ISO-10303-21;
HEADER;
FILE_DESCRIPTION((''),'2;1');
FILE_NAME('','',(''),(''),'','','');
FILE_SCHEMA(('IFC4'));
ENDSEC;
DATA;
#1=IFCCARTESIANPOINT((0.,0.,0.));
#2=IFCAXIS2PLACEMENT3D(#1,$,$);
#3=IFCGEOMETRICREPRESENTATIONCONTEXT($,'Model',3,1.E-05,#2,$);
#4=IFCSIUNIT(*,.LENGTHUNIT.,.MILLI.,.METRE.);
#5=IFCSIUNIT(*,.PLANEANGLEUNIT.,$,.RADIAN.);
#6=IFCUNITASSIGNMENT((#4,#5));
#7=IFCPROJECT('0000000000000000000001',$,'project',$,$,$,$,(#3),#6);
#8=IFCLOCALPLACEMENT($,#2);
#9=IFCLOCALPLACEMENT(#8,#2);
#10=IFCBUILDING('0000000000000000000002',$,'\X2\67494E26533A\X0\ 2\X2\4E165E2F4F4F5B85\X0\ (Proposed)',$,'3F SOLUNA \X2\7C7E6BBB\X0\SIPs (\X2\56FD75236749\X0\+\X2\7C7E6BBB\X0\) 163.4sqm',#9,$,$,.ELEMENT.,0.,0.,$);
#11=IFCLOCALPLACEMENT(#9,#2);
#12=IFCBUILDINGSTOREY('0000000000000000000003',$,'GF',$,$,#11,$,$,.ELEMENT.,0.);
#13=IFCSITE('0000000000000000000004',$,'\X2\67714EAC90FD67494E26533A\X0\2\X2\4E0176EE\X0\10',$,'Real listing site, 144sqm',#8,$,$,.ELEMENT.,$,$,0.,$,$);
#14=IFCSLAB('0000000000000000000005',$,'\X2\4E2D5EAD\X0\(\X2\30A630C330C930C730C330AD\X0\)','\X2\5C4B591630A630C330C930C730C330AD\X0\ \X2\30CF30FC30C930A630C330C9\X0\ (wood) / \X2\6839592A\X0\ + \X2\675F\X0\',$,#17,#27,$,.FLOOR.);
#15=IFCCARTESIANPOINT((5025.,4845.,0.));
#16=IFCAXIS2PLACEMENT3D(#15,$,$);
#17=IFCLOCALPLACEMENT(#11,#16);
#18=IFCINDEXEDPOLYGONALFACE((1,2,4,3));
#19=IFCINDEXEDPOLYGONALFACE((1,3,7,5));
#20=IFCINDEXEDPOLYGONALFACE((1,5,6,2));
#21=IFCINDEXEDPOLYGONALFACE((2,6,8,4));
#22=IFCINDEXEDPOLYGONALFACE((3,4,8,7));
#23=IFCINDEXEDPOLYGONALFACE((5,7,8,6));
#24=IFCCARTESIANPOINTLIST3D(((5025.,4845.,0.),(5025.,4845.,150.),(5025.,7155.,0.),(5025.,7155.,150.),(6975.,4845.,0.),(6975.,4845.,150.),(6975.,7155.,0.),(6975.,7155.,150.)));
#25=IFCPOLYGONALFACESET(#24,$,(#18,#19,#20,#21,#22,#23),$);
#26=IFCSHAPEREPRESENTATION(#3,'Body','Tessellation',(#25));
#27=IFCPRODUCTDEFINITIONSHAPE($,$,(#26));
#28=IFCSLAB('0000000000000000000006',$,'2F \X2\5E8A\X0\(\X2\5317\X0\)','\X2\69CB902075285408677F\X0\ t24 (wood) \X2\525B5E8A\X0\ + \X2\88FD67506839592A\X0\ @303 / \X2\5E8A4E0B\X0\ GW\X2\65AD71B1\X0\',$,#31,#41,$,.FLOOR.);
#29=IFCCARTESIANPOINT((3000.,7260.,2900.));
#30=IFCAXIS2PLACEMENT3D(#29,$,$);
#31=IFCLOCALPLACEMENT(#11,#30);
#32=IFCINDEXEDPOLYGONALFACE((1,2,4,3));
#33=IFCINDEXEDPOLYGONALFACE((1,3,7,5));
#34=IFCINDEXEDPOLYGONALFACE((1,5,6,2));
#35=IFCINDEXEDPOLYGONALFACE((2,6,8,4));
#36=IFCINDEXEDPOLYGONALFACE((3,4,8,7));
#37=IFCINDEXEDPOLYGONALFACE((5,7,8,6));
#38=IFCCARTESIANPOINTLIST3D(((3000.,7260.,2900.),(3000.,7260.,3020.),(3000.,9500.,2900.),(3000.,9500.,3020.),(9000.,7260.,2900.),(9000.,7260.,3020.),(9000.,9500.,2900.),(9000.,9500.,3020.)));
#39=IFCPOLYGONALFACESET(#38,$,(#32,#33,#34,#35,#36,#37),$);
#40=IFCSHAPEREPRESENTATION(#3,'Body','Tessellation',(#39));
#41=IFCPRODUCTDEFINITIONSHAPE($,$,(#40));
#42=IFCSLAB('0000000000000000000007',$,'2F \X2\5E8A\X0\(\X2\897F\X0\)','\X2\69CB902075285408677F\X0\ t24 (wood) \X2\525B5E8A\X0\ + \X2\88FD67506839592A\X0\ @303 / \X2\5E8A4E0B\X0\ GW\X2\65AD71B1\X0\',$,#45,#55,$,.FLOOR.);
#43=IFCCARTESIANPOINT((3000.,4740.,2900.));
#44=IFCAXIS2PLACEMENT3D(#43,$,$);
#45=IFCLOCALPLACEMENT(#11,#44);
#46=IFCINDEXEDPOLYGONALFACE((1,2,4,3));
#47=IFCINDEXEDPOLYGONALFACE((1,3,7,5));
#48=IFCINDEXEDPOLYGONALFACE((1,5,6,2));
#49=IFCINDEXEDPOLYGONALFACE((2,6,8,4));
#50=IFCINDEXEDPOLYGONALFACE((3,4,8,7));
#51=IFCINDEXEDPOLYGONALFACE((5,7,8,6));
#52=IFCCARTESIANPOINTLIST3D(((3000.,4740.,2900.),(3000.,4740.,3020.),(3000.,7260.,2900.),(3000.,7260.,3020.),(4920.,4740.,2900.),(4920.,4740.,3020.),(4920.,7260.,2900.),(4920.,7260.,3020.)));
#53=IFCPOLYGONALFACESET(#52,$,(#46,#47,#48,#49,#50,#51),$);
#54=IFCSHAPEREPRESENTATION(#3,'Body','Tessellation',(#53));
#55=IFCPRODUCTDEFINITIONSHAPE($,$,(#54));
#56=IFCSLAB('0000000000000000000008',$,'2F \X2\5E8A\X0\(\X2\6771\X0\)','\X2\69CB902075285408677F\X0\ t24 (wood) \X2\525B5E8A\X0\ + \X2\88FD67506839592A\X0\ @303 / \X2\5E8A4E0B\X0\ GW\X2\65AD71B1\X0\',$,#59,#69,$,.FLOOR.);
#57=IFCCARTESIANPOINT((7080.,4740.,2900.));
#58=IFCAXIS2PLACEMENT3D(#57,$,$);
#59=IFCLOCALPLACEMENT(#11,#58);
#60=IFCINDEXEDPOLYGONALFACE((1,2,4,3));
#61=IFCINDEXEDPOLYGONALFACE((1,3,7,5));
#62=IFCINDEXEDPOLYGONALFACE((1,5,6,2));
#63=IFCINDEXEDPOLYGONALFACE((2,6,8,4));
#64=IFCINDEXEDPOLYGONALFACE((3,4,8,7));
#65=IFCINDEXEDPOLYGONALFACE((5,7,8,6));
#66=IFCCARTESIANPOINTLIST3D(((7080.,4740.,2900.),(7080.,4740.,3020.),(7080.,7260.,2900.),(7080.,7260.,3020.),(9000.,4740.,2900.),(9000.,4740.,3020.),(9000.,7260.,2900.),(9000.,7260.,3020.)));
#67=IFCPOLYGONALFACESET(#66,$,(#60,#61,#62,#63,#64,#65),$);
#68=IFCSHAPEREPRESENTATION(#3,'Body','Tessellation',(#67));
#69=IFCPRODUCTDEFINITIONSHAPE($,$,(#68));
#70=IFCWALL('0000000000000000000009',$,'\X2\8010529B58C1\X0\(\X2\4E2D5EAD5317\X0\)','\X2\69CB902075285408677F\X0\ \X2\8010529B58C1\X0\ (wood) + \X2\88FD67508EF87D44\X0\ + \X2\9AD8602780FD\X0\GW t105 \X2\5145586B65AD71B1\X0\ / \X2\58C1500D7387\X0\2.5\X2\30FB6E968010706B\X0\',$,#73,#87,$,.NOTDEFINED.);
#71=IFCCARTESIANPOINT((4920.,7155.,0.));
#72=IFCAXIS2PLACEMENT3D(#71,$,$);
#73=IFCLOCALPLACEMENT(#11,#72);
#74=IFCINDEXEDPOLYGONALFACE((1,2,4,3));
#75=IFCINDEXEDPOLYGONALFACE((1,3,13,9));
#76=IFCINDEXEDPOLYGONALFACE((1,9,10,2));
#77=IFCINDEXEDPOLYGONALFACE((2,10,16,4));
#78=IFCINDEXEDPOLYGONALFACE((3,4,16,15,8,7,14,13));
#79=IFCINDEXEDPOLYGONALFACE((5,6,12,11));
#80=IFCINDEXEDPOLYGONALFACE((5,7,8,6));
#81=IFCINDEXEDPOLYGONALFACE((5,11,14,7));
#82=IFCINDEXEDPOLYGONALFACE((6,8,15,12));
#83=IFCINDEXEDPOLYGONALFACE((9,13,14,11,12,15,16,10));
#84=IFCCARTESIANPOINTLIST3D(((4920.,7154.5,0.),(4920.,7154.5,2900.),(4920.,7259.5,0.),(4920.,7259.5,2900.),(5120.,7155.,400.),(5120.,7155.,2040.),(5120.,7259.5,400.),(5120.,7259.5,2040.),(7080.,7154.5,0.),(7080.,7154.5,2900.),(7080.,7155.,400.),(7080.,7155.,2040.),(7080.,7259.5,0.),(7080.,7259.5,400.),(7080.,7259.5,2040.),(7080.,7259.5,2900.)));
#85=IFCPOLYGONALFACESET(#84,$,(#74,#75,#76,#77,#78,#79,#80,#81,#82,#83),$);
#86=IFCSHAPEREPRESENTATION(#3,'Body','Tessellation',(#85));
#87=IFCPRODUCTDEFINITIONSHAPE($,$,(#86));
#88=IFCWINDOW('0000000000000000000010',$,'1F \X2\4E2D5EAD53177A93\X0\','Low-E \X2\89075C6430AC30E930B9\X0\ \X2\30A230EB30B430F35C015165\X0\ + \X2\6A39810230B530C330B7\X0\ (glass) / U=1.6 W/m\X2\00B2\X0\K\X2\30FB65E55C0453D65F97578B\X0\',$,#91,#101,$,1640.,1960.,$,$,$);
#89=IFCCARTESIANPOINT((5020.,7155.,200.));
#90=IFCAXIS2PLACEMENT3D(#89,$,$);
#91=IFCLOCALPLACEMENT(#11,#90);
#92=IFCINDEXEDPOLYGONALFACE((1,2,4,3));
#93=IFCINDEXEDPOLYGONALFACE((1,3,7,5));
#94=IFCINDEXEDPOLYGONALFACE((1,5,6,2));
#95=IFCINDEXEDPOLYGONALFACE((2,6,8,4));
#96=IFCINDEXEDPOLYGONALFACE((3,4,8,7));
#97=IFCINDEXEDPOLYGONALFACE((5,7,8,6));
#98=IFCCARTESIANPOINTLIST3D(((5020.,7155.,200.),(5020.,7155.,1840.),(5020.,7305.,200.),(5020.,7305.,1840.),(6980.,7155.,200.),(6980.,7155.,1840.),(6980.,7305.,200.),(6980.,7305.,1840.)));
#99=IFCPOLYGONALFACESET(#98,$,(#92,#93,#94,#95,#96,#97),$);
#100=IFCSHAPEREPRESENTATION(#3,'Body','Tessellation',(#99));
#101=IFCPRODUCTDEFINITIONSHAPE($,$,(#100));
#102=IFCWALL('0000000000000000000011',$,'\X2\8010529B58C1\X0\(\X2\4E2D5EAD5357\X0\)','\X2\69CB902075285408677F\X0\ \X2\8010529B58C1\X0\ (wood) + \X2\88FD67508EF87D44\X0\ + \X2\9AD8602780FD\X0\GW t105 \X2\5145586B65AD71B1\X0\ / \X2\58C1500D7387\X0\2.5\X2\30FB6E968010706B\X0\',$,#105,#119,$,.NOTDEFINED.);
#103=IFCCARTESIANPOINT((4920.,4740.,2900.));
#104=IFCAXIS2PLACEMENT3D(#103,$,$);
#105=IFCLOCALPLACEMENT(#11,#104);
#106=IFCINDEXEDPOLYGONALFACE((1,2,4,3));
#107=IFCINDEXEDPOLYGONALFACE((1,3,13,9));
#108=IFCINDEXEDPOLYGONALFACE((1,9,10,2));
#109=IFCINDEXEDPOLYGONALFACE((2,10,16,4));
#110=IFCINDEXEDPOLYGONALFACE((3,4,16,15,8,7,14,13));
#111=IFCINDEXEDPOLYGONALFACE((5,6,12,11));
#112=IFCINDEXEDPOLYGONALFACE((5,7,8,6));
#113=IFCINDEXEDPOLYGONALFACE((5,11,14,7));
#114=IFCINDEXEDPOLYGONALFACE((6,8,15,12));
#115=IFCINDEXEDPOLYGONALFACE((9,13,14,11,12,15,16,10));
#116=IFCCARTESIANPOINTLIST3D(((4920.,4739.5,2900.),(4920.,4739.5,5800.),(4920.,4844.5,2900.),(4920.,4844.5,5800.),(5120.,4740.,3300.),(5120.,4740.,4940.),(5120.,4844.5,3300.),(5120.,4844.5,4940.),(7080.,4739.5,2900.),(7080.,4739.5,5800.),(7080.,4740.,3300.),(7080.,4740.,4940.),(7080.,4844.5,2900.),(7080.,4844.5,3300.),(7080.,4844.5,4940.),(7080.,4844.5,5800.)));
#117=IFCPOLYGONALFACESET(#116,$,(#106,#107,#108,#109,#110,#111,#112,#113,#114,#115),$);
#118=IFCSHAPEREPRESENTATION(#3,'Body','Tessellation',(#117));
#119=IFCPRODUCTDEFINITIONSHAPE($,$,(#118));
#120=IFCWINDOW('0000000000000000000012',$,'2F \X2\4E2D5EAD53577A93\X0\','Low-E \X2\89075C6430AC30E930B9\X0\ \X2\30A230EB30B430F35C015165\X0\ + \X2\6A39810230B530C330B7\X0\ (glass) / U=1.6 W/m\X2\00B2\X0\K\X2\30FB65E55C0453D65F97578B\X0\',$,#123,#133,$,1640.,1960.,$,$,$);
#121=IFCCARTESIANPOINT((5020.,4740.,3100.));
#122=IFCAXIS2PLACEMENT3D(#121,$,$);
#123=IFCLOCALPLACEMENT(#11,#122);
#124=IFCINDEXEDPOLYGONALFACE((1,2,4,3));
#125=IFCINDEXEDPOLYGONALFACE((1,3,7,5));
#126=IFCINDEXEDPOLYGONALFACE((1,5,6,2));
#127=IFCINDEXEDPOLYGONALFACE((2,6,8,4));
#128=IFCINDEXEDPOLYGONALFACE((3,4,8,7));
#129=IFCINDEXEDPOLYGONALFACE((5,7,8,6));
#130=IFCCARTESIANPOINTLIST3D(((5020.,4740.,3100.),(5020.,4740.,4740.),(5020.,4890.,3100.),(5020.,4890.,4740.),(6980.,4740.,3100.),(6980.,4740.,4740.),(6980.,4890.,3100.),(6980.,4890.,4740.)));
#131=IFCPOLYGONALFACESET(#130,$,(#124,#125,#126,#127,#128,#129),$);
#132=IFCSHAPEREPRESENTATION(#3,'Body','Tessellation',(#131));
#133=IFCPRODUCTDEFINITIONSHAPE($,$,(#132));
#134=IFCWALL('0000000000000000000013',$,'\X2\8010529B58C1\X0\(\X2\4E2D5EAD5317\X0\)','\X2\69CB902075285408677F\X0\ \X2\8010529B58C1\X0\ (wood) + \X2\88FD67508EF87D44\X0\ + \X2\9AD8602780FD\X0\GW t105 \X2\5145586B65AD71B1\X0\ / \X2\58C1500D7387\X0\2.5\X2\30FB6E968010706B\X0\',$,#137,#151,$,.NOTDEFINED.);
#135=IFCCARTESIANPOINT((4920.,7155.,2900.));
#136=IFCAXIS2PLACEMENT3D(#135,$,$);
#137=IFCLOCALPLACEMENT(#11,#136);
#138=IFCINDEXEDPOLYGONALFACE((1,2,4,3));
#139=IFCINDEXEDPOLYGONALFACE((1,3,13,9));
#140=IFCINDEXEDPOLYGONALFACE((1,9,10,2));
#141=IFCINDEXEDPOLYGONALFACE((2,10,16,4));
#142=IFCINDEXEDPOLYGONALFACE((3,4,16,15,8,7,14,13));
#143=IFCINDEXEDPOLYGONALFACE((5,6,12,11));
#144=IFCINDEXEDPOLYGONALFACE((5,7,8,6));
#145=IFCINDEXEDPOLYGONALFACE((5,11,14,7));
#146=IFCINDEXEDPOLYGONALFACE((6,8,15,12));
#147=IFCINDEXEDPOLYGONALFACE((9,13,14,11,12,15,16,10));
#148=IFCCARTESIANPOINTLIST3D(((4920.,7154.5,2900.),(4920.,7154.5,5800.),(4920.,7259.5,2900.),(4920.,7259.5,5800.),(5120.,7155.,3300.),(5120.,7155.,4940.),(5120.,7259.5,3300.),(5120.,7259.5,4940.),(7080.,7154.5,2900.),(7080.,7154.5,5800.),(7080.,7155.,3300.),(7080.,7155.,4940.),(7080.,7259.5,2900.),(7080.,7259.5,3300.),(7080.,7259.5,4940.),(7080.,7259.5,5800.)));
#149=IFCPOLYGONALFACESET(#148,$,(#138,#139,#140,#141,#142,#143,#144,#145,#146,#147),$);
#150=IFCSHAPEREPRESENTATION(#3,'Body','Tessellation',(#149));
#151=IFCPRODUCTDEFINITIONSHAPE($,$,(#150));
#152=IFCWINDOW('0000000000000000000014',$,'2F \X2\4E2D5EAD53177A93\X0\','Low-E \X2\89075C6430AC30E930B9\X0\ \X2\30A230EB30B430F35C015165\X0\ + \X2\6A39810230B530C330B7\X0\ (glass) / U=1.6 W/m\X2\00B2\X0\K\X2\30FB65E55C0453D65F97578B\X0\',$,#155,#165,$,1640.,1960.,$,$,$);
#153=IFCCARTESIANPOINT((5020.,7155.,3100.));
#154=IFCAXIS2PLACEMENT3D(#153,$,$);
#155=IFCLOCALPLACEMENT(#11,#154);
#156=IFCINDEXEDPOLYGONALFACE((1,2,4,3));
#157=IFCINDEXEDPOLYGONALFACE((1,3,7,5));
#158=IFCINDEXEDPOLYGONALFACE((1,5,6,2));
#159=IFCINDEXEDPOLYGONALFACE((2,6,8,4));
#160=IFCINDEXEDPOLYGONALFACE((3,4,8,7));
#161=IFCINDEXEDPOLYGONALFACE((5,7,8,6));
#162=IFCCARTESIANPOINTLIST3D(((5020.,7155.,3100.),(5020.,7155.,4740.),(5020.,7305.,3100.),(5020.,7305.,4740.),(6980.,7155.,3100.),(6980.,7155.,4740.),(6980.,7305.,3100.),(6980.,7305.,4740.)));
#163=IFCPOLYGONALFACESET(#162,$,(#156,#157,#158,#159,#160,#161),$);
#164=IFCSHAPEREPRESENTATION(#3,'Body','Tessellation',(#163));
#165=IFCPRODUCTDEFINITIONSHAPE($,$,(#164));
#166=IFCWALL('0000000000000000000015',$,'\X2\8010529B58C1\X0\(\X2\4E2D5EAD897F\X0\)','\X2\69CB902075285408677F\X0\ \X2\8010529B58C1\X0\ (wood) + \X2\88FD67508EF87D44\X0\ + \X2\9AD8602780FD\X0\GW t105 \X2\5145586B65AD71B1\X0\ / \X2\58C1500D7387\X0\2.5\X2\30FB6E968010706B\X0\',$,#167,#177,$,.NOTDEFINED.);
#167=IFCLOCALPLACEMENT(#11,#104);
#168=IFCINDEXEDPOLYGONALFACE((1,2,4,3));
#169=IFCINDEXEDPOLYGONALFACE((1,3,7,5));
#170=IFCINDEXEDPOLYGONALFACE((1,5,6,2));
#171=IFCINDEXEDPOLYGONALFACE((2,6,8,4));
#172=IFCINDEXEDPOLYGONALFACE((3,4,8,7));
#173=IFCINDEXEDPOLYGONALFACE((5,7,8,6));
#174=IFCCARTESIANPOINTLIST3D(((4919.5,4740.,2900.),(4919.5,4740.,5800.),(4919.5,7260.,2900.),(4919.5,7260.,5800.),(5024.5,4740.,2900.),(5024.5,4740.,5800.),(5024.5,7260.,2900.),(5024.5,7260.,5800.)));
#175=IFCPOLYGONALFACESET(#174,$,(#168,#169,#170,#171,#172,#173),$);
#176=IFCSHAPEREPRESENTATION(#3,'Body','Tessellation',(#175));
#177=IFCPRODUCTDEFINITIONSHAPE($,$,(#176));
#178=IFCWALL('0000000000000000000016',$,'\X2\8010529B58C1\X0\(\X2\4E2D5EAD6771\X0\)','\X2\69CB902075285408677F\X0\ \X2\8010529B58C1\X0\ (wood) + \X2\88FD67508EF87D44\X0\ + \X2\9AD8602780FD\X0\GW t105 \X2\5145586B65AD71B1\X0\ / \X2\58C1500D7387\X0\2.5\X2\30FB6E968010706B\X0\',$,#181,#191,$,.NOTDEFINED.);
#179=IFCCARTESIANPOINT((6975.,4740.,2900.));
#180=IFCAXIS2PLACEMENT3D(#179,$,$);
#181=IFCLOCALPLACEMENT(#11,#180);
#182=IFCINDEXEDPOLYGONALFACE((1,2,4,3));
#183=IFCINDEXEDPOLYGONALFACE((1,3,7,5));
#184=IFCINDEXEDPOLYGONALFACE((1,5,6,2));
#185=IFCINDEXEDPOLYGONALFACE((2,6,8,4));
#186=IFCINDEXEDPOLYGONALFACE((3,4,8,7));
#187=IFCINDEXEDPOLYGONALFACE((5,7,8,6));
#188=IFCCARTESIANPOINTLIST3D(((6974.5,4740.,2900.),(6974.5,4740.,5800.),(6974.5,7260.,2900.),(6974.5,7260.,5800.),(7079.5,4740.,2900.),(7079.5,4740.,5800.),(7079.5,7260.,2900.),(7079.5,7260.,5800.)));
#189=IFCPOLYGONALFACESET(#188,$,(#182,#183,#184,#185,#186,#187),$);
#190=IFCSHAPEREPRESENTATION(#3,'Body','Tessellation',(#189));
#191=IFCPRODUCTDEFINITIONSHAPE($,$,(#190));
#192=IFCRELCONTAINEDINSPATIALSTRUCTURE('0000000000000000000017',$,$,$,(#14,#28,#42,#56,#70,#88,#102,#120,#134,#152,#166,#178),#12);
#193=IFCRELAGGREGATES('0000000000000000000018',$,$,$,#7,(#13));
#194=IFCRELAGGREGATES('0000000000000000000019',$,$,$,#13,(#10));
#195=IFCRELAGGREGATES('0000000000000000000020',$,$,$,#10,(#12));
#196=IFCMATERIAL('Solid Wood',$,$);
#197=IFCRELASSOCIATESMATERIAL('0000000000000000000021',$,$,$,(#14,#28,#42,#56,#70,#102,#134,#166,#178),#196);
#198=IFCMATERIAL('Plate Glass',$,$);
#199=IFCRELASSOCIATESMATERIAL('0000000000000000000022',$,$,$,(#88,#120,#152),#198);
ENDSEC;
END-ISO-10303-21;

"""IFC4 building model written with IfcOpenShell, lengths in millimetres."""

from ifc_helpers import new_model, si_unit, frame, frame_2d, origin, place, context, project, spatial, rectangle, extrude, material, element, fill, save


model = new_model("IFC4")

# Units and contexts
model_context = context("Model", 3, precision=1e-05, world=origin())
ifc_project = project(units=[si_unit("LENGTHUNIT", "METRE", prefix="MILLI"), si_unit("PLANEANGLEUNIT", "RADIAN")], contexts=[model_context])

# Site, building, storey
site_placement = place(None, origin())
site = spatial("IfcSite", under=ifc_project, at=site_placement, Name="東京都杉並区2丁目10", ObjectType="Real listing site, 144sqm", CompositionType="ELEMENT", RefElevation=0.0)
building_placement = place(site_placement, origin())
building = spatial("IfcBuilding", under=site, at=building_placement, Name="杉並区 2世帯住宅 (Proposed)", ObjectType="3F SOLUNA 籾殻SIPs (国産杉+籾殻) 163.4sqm", CompositionType="ELEMENT", ElevationOfRefHeight=0.0, ElevationOfTerrain=0.0)
storey_placement = place(building_placement, origin())
storey = spatial("IfcBuildingStorey", under=building, at=storey_placement, Name="GF", CompositionType="ELEMENT", Elevation=0.0)

# Slabs
ifc_material_1 = material(Name="Solid Wood")
slab_1_placement = place(storey_placement, frame((5025.0, 4845.0, 0.0)))
element("IfcSlab", 1, at=slab_1_placement, inside=storey, material=ifc_material_1, Name="中庭(ウッドデッキ)", Description="屋外ウッドデッキ ハードウッド (wood) / 根太 + 束", PredefinedType="FLOOR", context=model_context, shape_type="SweptSolid", body=[
    extrude(rectangle(XDim=1950.0, YDim=2310.0, at=frame_2d((975.0, 1155.0))), frame((5025.0, 4845.0, 0.0)), (0.0, 0.0, 1.0), 150.0),
])
slab_2_placement = place(storey_placement, frame((3000.0, 7260.0, 2900.0)))
element("IfcSlab", 2, at=slab_2_placement, inside=storey, material=ifc_material_1, Name="2F 床(北)", Description="構造用合板 t24 (wood) 剛床 + 製材根太 @303 / 床下 GW断熱", PredefinedType="FLOOR", context=model_context, shape_type="SweptSolid", body=[
    extrude(rectangle(XDim=6000.0, YDim=2240.0, at=frame_2d((3000.0, 1120.0))), frame((3000.0, 7260.0, 2900.0)), (0.0, 0.0, 1.0), 120.0),
])
slab_3_placement = place(storey_placement, frame((3000.0, 4740.0, 2900.0)))
element("IfcSlab", 3, at=slab_3_placement, inside=storey, material=ifc_material_1, Name="2F 床(西)", Description="構造用合板 t24 (wood) 剛床 + 製材根太 @303 / 床下 GW断熱", PredefinedType="FLOOR", context=model_context, shape_type="SweptSolid", body=[
    extrude(rectangle(XDim=1920.0, YDim=2520.0, at=frame_2d((960.0, 1260.0))), frame((3000.0, 4740.0, 2900.0)), (0.0, 0.0, 1.0), 120.0),
])
slab_4_placement = place(storey_placement, frame((7080.0, 4740.0, 2900.0)))
element("IfcSlab", 4, at=slab_4_placement, inside=storey, material=ifc_material_1, Name="2F 床(東)", Description="構造用合板 t24 (wood) 剛床 + 製材根太 @303 / 床下 GW断熱", PredefinedType="FLOOR", context=model_context, shape_type="SweptSolid", body=[
    extrude(rectangle(XDim=1920.0, YDim=2520.0, at=frame_2d((960.0, 1260.0))), frame((7080.0, 4740.0, 2900.0)), (0.0, 0.0, 1.0), 120.0),
])

# Wall, opening, window
wall_1_placement = place(storey_placement, frame((4920.0, 7155.0, 0.0)))
wall_1 = element("IfcWall", 5, at=wall_1_placement, inside=storey, material=ifc_material_1, Name="耐力壁(中庭北)", Description="構造用合板 耐力壁 (wood) + 製材軸組 + 高性能GW t105 充填断熱 / 壁倍率2.5・準耐火", PredefinedType="NOTDEFINED", context=model_context, shape_type="SweptSolid", body=[
    extrude(rectangle(XDim=2160.0, YDim=105.0, at=frame_2d((1080.0, 52.0))), frame((4920.0, 7155.0, 0.0)), (0.0, 0.0, 1.0), 2900.0),
])
opening_1_placement = place(storey_placement, frame((5020.0, 7155.0, 200.0)))
opening_1 = element("IfcOpeningElement", 6, at=opening_1_placement, cuts=wall_1, PredefinedType="NOTDEFINED", context=model_context, shape_type="SweptSolid", body=[
    extrude(rectangle(XDim=1960.0, YDim=150.0, at=frame_2d((980.0, 75.0))), frame((5020.0, 7155.0, 200.0)), (0.0, 0.0, 1.0), 1640.0),
])
ifc_material_2 = material(Name="Plate Glass")
window_1_placement = place(storey_placement, frame((5020.0, 7155.0, 200.0)))
window_1 = element("IfcWindow", 7, at=window_1_placement, inside=storey, material=ifc_material_2, Name="1F 中庭北窓", Description="Low-E 複層ガラス アルゴン封入 + 樹脂サッシ (glass) / U=1.6 W/m²K・日射取得型", OverallHeight=1640.0, OverallWidth=1960.0, context=model_context, shape_type="SweptSolid", body=[
    extrude(rectangle(XDim=1960.0, YDim=150.0, at=frame_2d((980.0, 75.0))), frame((5020.0, 7155.0, 200.0)), (0.0, 0.0, 1.0), 1640.0),
])
fill(opening_1, window_1)

# Walls, openings, windows
wall_2_placement = place(storey_placement, frame((4920.0, 4740.0, 2900.0)))
wall_2 = element("IfcWall", 8, at=wall_2_placement, inside=storey, material=ifc_material_1, Name="耐力壁(中庭南)", Description="構造用合板 耐力壁 (wood) + 製材軸組 + 高性能GW t105 充填断熱 / 壁倍率2.5・準耐火", PredefinedType="NOTDEFINED", context=model_context, shape_type="SweptSolid", body=[
    extrude(rectangle(XDim=2160.0, YDim=105.0, at=frame_2d((1080.0, 52.0))), frame((4920.0, 4740.0, 2900.0)), (0.0, 0.0, 1.0), 2900.0),
])
opening_2_placement = place(storey_placement, frame((5020.0, 4740.0, 3100.0)))
opening_2 = element("IfcOpeningElement", 9, at=opening_2_placement, cuts=wall_2, PredefinedType="NOTDEFINED", context=model_context, shape_type="SweptSolid", body=[
    extrude(rectangle(XDim=1960.0, YDim=150.0, at=frame_2d((980.0, 75.0))), frame((5020.0, 4740.0, 3100.0)), (0.0, 0.0, 1.0), 1640.0),
])
window_2_placement = place(storey_placement, frame((5020.0, 4740.0, 3100.0)))
window_2 = element("IfcWindow", 10, at=window_2_placement, inside=storey, material=ifc_material_2, Name="2F 中庭南窓", Description="Low-E 複層ガラス アルゴン封入 + 樹脂サッシ (glass) / U=1.6 W/m²K・日射取得型", OverallHeight=1640.0, OverallWidth=1960.0, context=model_context, shape_type="SweptSolid", body=[
    extrude(rectangle(XDim=1960.0, YDim=150.0, at=frame_2d((980.0, 75.0))), frame((5020.0, 4740.0, 3100.0)), (0.0, 0.0, 1.0), 1640.0),
])
fill(opening_2, window_2)
wall_3_placement = place(storey_placement, frame((4920.0, 7155.0, 2900.0)))
wall_3 = element("IfcWall", 11, at=wall_3_placement, inside=storey, material=ifc_material_1, Name="耐力壁(中庭北)", Description="構造用合板 耐力壁 (wood) + 製材軸組 + 高性能GW t105 充填断熱 / 壁倍率2.5・準耐火", PredefinedType="NOTDEFINED", context=model_context, shape_type="SweptSolid", body=[
    extrude(rectangle(XDim=2160.0, YDim=105.0, at=frame_2d((1080.0, 52.0))), frame((4920.0, 7155.0, 2900.0)), (0.0, 0.0, 1.0), 2900.0),
])
opening_3_placement = place(storey_placement, frame((5020.0, 7155.0, 3100.0)))
opening_3 = element("IfcOpeningElement", 12, at=opening_3_placement, cuts=wall_3, PredefinedType="NOTDEFINED", context=model_context, shape_type="SweptSolid", body=[
    extrude(rectangle(XDim=1960.0, YDim=150.0, at=frame_2d((980.0, 75.0))), frame((5020.0, 7155.0, 3100.0)), (0.0, 0.0, 1.0), 1640.0),
])
window_3_placement = place(storey_placement, frame((5020.0, 7155.0, 3100.0)))
window_3 = element("IfcWindow", 13, at=window_3_placement, inside=storey, material=ifc_material_2, Name="2F 中庭北窓", Description="Low-E 複層ガラス アルゴン封入 + 樹脂サッシ (glass) / U=1.6 W/m²K・日射取得型", OverallHeight=1640.0, OverallWidth=1960.0, context=model_context, shape_type="SweptSolid", body=[
    extrude(rectangle(XDim=1960.0, YDim=150.0, at=frame_2d((980.0, 75.0))), frame((5020.0, 7155.0, 3100.0)), (0.0, 0.0, 1.0), 1640.0),
])
fill(opening_3, window_3)

# Walls
wall_4_placement = place(storey_placement, frame((4920.0, 4740.0, 2900.0)))
element("IfcWall", 14, at=wall_4_placement, inside=storey, material=ifc_material_1, Name="耐力壁(中庭西)", Description="構造用合板 耐力壁 (wood) + 製材軸組 + 高性能GW t105 充填断熱 / 壁倍率2.5・準耐火", PredefinedType="NOTDEFINED", context=model_context, shape_type="SweptSolid", body=[
    extrude(rectangle(XDim=105.0, YDim=2520.0, at=frame_2d((52.0, 1260.0))), frame((4920.0, 4740.0, 2900.0)), (0.0, 0.0, 1.0), 2900.0),
])
wall_5_placement = place(storey_placement, frame((6975.0, 4740.0, 2900.0)))
element("IfcWall", 15, at=wall_5_placement, inside=storey, material=ifc_material_1, Name="耐力壁(中庭東)", Description="構造用合板 耐力壁 (wood) + 製材軸組 + 高性能GW t105 充填断熱 / 壁倍率2.5・準耐火", PredefinedType="NOTDEFINED", context=model_context, shape_type="SweptSolid", body=[
    extrude(rectangle(XDim=105.0, YDim=2520.0, at=frame_2d((52.0, 1260.0))), frame((6975.0, 4740.0, 2900.0)), (0.0, 0.0, 1.0), 2900.0),
])

save(model, "model.ifc")
